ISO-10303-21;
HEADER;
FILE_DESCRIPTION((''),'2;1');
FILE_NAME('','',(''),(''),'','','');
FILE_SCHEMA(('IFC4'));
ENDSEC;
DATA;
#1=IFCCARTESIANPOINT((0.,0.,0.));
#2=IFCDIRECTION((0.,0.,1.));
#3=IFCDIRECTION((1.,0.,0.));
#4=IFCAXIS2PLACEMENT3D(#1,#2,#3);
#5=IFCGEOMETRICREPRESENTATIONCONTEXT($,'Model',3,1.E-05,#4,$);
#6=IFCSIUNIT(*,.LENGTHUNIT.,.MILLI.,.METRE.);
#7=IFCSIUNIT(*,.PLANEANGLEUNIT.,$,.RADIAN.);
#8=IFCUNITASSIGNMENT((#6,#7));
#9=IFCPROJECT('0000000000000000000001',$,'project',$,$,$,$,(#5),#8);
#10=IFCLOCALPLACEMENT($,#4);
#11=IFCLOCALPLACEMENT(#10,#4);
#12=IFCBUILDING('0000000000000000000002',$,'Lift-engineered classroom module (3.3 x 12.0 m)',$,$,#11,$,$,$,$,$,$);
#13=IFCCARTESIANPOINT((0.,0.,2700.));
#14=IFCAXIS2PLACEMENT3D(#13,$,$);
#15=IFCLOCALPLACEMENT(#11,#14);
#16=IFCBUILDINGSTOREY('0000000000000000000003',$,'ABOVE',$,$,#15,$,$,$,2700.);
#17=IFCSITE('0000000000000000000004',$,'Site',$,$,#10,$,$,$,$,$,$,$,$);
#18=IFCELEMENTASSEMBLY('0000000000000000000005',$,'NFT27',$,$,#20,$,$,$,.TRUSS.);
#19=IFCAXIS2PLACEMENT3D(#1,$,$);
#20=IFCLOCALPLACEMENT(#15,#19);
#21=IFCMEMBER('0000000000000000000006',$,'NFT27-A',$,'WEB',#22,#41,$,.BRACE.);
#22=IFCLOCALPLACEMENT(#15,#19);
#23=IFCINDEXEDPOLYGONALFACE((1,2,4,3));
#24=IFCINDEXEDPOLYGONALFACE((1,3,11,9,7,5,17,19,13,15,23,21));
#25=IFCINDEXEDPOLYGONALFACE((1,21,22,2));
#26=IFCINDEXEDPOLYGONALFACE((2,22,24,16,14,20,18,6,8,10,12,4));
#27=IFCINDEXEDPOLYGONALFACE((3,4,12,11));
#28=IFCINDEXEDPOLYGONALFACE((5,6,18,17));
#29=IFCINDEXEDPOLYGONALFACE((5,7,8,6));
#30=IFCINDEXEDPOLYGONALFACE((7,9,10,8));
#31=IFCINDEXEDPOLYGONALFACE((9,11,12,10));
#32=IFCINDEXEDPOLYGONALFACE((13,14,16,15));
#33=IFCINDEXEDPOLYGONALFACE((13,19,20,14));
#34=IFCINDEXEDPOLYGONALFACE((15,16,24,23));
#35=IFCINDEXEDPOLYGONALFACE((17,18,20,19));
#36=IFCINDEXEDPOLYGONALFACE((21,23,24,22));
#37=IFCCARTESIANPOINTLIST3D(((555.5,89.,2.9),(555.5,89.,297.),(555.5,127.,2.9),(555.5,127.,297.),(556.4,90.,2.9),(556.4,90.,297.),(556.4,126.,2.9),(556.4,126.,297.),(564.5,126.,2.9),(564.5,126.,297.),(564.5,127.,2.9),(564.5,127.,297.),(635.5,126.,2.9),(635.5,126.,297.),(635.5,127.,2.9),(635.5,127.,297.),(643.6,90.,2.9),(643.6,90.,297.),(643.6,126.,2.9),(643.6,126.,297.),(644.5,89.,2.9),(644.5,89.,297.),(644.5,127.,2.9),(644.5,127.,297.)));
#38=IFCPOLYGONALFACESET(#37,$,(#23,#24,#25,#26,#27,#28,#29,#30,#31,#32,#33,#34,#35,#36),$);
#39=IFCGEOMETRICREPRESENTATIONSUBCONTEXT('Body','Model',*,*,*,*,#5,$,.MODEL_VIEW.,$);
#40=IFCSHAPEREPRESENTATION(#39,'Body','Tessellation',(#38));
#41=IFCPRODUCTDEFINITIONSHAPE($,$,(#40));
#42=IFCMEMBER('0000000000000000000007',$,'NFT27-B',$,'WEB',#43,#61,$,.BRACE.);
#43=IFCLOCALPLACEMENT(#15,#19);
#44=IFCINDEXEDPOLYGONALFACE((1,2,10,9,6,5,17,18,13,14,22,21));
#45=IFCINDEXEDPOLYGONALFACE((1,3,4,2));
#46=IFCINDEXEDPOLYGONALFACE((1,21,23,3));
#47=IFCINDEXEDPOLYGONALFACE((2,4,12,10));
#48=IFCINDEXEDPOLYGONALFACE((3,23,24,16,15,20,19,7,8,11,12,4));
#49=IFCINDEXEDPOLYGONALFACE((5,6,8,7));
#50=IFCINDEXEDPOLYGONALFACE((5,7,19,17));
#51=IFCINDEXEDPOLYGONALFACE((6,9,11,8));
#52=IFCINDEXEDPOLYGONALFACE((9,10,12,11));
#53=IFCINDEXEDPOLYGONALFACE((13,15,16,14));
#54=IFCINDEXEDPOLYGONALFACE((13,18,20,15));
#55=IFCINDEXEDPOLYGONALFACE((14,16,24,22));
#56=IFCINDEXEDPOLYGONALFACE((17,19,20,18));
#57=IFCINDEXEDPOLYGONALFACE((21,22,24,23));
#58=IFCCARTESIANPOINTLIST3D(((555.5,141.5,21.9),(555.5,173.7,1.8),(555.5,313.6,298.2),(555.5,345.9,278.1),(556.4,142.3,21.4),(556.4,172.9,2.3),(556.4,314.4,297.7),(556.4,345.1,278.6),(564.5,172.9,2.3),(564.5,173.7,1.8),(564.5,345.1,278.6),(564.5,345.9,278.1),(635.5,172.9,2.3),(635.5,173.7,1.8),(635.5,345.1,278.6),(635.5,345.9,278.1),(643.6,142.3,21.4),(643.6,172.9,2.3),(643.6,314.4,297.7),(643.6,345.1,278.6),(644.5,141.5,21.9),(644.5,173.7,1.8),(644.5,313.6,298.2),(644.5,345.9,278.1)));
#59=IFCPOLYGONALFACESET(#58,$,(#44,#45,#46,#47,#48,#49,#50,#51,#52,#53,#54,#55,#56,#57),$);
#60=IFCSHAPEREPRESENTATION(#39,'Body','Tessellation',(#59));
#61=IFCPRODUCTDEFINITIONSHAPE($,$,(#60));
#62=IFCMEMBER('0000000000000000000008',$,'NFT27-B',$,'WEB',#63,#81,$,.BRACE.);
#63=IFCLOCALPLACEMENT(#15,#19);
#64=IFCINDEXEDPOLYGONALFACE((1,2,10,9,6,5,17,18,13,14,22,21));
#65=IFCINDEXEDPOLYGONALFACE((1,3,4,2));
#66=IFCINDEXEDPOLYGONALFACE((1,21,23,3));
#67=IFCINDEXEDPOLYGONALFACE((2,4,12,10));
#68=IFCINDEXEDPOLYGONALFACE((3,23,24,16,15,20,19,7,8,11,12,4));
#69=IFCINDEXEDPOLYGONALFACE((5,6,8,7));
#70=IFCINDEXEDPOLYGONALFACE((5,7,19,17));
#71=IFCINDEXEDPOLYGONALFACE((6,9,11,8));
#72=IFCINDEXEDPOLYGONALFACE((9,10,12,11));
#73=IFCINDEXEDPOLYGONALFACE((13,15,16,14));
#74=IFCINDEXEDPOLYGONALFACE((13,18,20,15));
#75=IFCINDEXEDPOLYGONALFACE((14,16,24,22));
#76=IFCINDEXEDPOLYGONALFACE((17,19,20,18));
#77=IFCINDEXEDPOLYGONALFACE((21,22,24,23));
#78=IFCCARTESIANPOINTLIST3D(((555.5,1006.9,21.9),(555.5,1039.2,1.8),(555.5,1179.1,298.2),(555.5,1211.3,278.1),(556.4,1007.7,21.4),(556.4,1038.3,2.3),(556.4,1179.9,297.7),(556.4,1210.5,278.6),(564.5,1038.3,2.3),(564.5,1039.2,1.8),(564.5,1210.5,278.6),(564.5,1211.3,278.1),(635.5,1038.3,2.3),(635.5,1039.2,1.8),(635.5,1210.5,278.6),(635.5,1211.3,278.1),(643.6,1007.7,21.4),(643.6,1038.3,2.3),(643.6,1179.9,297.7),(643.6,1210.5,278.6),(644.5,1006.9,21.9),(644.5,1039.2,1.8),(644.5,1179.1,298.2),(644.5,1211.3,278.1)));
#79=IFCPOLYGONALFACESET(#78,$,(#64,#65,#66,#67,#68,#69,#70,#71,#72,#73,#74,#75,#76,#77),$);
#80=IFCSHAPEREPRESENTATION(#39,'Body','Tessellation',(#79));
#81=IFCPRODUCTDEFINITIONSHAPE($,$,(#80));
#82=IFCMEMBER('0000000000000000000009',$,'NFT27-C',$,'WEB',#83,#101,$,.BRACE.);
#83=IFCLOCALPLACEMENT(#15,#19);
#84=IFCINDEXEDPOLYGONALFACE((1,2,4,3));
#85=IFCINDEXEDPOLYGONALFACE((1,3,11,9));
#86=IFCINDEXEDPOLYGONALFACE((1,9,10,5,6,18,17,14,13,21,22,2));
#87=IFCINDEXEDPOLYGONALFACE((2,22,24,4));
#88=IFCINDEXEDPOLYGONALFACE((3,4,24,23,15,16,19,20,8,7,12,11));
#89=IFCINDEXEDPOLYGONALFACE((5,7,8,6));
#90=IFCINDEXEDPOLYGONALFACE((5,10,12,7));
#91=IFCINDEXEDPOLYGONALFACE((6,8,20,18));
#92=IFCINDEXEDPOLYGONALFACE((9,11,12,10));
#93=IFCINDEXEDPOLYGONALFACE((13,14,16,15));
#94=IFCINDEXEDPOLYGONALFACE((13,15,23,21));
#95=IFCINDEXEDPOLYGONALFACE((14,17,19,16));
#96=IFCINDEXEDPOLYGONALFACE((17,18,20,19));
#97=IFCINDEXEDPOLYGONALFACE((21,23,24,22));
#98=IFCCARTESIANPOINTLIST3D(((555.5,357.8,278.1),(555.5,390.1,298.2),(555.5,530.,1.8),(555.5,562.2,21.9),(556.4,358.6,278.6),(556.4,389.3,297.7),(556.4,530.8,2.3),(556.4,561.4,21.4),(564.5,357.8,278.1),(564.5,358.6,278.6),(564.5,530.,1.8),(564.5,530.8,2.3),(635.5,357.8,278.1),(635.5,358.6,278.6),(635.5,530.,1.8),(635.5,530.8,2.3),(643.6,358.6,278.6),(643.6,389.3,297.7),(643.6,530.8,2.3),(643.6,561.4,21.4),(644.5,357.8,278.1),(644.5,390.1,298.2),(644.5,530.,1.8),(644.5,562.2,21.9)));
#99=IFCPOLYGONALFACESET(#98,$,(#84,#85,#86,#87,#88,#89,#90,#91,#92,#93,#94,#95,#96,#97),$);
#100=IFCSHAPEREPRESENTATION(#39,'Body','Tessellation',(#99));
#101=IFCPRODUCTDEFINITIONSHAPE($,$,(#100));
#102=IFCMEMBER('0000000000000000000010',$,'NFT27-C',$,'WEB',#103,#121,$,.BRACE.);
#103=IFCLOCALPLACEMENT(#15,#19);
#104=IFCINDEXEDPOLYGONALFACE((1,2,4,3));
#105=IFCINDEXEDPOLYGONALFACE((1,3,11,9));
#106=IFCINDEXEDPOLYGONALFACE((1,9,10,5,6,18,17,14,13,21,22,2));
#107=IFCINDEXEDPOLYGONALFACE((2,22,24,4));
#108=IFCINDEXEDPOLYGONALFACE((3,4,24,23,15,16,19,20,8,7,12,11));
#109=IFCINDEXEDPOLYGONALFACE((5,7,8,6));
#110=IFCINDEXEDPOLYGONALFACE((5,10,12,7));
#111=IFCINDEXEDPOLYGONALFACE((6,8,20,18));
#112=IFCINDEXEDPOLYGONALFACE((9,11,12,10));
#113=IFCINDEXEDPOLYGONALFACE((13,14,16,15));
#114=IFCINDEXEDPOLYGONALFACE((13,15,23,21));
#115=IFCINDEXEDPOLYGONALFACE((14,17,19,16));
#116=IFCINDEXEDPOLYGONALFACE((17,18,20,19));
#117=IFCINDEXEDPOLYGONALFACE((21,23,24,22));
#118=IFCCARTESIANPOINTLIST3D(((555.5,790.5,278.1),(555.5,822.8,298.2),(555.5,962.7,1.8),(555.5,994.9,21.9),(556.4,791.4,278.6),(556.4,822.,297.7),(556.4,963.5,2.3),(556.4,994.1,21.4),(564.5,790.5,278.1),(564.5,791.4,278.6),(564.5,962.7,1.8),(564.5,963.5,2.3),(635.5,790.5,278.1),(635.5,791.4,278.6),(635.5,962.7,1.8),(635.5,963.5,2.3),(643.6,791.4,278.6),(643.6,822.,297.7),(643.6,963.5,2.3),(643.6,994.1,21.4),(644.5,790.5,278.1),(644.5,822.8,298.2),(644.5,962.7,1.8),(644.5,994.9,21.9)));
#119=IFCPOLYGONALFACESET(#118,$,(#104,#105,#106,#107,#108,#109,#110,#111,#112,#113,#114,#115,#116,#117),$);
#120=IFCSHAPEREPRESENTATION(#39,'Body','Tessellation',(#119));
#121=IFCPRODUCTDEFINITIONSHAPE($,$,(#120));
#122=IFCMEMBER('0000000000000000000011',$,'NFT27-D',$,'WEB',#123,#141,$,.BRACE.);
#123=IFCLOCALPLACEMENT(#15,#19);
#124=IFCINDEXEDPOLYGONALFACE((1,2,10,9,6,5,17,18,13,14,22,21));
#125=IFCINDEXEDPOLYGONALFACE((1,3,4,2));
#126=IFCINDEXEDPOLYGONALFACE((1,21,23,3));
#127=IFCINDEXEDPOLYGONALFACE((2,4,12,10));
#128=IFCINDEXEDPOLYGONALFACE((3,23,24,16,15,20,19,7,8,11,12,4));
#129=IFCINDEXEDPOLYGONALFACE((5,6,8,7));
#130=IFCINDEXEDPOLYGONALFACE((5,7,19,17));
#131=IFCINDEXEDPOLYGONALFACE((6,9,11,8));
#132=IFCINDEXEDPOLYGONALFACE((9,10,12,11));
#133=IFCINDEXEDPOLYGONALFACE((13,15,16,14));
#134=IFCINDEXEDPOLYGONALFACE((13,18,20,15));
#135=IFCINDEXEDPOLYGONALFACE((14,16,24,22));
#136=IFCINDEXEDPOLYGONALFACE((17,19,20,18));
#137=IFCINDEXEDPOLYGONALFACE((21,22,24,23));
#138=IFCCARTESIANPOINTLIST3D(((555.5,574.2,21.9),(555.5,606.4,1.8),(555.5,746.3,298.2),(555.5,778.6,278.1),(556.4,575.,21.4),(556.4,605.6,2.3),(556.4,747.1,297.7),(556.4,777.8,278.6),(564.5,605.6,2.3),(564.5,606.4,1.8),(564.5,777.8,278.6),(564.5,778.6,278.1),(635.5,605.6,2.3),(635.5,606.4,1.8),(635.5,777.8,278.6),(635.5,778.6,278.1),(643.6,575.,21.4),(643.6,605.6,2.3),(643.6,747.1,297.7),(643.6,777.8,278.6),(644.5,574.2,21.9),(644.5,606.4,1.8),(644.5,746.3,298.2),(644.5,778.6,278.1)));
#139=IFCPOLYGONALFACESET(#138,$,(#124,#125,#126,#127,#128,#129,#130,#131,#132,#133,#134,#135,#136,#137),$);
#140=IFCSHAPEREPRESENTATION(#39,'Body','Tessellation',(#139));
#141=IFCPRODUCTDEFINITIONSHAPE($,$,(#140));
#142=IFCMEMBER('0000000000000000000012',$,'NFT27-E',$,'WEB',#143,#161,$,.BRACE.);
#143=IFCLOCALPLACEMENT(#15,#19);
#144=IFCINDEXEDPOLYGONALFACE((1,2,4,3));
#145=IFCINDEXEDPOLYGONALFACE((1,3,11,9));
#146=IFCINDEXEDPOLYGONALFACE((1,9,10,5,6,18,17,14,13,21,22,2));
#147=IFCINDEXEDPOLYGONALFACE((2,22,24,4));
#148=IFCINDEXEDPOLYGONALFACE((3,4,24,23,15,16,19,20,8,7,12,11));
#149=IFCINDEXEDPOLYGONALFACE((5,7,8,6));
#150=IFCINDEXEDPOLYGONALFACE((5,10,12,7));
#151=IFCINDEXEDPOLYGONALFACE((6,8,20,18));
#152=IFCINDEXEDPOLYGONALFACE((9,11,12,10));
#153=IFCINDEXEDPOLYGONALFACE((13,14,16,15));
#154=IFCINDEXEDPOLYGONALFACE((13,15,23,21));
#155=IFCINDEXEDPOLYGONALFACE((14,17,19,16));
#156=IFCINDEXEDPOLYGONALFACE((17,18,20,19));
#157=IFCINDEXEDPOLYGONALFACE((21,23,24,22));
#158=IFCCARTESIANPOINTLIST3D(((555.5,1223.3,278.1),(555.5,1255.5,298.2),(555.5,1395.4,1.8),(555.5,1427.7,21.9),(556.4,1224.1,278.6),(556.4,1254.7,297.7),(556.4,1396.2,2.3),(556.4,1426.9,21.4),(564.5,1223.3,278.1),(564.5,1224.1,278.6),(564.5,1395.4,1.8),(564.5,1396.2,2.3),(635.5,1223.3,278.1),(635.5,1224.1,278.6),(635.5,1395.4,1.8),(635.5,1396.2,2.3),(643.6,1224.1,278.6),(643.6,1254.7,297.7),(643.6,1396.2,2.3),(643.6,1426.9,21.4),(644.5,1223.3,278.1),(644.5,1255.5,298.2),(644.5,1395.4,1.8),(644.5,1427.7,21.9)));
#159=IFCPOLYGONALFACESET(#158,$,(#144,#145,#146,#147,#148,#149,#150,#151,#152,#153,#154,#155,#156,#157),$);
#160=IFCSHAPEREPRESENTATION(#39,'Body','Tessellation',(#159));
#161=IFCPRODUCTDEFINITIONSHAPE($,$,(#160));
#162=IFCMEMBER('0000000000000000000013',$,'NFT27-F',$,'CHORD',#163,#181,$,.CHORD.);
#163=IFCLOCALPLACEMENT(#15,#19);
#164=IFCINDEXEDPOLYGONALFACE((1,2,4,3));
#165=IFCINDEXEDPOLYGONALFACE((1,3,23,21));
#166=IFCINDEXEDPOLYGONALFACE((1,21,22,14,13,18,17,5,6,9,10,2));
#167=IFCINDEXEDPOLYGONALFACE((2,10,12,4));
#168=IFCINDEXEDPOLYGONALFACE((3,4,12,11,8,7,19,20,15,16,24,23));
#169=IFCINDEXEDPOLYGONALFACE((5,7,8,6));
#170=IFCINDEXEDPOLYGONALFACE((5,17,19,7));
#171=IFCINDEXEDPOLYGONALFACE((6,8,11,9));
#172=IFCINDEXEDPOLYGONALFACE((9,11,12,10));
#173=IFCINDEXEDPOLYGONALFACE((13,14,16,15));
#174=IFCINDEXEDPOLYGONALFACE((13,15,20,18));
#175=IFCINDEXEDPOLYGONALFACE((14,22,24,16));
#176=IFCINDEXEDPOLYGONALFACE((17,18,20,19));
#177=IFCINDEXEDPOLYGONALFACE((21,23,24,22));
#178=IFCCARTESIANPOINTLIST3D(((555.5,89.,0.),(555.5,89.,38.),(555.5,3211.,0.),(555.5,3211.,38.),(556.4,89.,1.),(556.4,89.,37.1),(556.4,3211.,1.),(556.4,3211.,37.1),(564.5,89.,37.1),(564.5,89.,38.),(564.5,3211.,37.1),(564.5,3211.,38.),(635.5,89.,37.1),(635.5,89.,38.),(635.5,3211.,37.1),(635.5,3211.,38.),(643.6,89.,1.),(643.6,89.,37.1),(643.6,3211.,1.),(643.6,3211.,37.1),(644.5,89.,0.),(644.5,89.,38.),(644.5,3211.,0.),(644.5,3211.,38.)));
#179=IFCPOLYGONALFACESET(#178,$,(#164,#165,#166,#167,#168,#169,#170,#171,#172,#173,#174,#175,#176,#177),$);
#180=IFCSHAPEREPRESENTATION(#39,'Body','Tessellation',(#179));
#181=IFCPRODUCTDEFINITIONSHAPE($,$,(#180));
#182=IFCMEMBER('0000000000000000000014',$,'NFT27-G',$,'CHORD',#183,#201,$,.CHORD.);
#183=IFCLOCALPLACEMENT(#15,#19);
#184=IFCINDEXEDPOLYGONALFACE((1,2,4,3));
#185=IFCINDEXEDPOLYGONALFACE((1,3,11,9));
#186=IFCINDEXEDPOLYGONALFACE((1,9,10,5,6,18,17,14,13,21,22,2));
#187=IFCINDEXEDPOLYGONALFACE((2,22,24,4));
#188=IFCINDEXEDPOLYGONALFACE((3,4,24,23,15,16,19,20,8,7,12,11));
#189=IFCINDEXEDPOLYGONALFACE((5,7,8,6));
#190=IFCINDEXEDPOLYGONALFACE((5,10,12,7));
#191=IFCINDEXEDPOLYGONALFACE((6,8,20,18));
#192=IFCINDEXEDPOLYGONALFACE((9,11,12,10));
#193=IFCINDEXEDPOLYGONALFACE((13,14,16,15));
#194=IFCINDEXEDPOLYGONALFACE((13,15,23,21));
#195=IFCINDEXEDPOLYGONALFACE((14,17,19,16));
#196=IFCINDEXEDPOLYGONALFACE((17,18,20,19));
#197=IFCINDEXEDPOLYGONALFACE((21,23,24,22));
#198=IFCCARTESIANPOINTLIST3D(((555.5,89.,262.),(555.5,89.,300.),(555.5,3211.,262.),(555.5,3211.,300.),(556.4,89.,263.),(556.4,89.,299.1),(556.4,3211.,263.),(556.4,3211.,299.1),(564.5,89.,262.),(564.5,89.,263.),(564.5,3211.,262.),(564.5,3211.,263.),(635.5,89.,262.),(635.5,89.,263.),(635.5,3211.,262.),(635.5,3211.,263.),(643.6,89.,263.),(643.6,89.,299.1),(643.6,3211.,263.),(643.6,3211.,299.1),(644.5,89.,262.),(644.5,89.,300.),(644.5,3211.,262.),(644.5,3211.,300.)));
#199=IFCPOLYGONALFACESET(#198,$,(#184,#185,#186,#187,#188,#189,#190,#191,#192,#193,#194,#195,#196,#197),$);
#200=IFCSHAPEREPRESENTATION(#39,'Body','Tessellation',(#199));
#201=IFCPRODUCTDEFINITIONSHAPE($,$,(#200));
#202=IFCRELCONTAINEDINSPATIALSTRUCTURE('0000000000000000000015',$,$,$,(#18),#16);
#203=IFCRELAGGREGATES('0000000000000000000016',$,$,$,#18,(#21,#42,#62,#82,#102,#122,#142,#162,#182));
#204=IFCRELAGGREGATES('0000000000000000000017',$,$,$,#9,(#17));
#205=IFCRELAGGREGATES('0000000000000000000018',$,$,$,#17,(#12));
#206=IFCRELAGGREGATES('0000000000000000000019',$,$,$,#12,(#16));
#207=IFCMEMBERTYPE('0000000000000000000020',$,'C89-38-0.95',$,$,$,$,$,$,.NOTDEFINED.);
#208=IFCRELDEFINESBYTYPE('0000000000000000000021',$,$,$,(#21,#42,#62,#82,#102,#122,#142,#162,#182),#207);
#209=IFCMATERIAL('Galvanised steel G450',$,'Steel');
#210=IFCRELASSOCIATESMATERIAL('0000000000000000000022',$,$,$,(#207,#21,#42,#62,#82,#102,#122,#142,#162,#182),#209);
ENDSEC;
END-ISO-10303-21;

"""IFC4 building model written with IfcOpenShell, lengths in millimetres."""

from ifc_helpers import new_model, si_unit, frame, origin, origin_with_axes, origin_2d, place, context, subcontext, project, spatial, c_section, extrude, material, material_profile, profile_set, profile_usage, type_object, element, aggregate, save


model = new_model("IFC4")

# Units and contexts
model_context = context("Model", 3, precision=1e-05, world=origin_with_axes())
body_context = subcontext(model_context, "Body", "Model", "MODEL_VIEW")
ifc_project = project(units=[si_unit("LENGTHUNIT", "METRE", prefix="MILLI"), si_unit("PLANEANGLEUNIT", "RADIAN")], contexts=[model_context])

# Site, building, storey
site_placement = place(None, origin_with_axes())
site = spatial("IfcSite", under=ifc_project, at=site_placement, Name="Site")
building_placement = place(site_placement, origin_with_axes())
building = spatial("IfcBuilding", under=site, at=building_placement, Name="Lift-engineered classroom module (3.3 x 12.0 m)")
storey_placement = place(building_placement, frame((0.0, 0.0, 2700.0)))
storey = spatial("IfcBuildingStorey", under=building, at=storey_placement, Name="ABOVE", Elevation=2700.0)

# Element assembly, members
ifc_material = material(Name="Galvanised steel G450", Category="Steel")
ifc_material_profile = material_profile(ifc_material, c_section(Depth=89.0, Width=38.0, WallThickness=0.9, Girth=9.0, at=origin_2d()), Name="C89-38-0.95")
ifc_profile_set = profile_set([ifc_material_profile], Name="C89-38-0.95")
ifc_profile_usage = profile_usage(ifc_profile_set)
member_type = type_object("IfcMemberType", Name="C89-38-0.95", PredefinedType="NOTDEFINED", material=ifc_profile_set)
assembly_1_placement = place(storey_placement, frame((600.0, 89.0, 0.0)))
assembly_1 = element("IfcElementAssembly", 1, at=assembly_1_placement, inside=storey, Name="NFT27", PredefinedType="TRUSS")
member_1_placement = place(assembly_1_placement, frame((0.0, 19.0, 2.9), z_axis=(0.0, 0.0, 1.0), x_axis=(0.0, 1.0, 0.0)))
member_1 = element("IfcMember", 2, at=member_1_placement, type_object=member_type, material=ifc_profile_usage, Name="NFT27-A", ObjectType="WEB", PredefinedType="BRACE", context=body_context, shape_type="SweptSolid", body=[
    extrude(c_section(Depth=89.0, Width=38.0, WallThickness=0.9, Girth=9.0, at=origin_2d()), origin(), (0.0, 0.0, 1.0), 294.1),
])
member_2_placement = place(assembly_1_placement, frame((0.0, 68.6, 11.8), z_axis=(0.0, 0.528797, 0.848748), x_axis=(0.0, 0.848748, -0.528797)))
member_2 = element("IfcMember", 3, at=member_2_placement, type_object=member_type, material=ifc_profile_usage, Name="NFT27-B", ObjectType="WEB", PredefinedType="BRACE", context=body_context, shape_type="SweptSolid", body=[
    extrude(c_section(Depth=89.0, Width=38.0, WallThickness=0.9, Girth=9.0, at=origin_2d()), origin(), (0.0, 0.0, 1.0), 325.6),
])
member_3_placement = place(assembly_1_placement, frame((0.0, 934.0, 11.8), z_axis=(0.0, 0.528797, 0.848748), x_axis=(0.0, 0.848748, -0.528797)))
member_3 = element("IfcMember", 4, at=member_3_placement, type_object=member_type, material=ifc_profile_usage, Name="NFT27-B", ObjectType="WEB", PredefinedType="BRACE", context=body_context, shape_type="SweptSolid", body=[
    extrude(c_section(Depth=89.0, Width=38.0, WallThickness=0.9, Girth=9.0, at=origin_2d()), origin(), (0.0, 0.0, 1.0), 325.6),
])
member_4_placement = place(assembly_1_placement, frame((0.0, 457.1, 11.8), z_axis=(0.0, -0.528797, 0.848748), x_axis=(0.0, -0.848748, -0.528797)))
member_4 = element("IfcMember", 5, at=member_4_placement, type_object=member_type, material=ifc_profile_usage, Name="NFT27-C", ObjectType="WEB", PredefinedType="BRACE", context=body_context, shape_type="SweptSolid", body=[
    extrude(c_section(Depth=89.0, Width=38.0, WallThickness=0.9, Girth=9.0, at=origin_2d()), origin(), (0.0, 0.0, 1.0), 325.6),
])
member_5_placement = place(assembly_1_placement, frame((0.0, 889.8, 11.8), z_axis=(0.0, -0.528797, 0.848748), x_axis=(0.0, -0.848748, -0.528797)))
member_5 = element("IfcMember", 6, at=member_5_placement, type_object=member_type, material=ifc_profile_usage, Name="NFT27-C", ObjectType="WEB", PredefinedType="BRACE", context=body_context, shape_type="SweptSolid", body=[
    extrude(c_section(Depth=89.0, Width=38.0, WallThickness=0.9, Girth=9.0, at=origin_2d()), origin(), (0.0, 0.0, 1.0), 325.6),
])
member_6_placement = place(assembly_1_placement, frame((0.0, 501.3, 11.8), z_axis=(0.0, 0.528775, 0.848762), x_axis=(0.0, 0.848762, -0.528775)))
member_6 = element("IfcMember", 7, at=member_6_placement, type_object=member_type, material=ifc_profile_usage, Name="NFT27-D", ObjectType="WEB", PredefinedType="BRACE", context=body_context, shape_type="SweptSolid", body=[
    extrude(c_section(Depth=89.0, Width=38.0, WallThickness=0.9, Girth=9.0, at=origin_2d()), origin(), (0.0, 0.0, 1.0), 325.6),
])
member_7_placement = place(assembly_1_placement, frame((0.0, 1322.5, 11.8), z_axis=(0.0, -0.528775, 0.848762), x_axis=(0.0, -0.848762, -0.528775)))
member_7 = element("IfcMember", 8, at=member_7_placement, type_object=member_type, material=ifc_profile_usage, Name="NFT27-E", ObjectType="WEB", PredefinedType="BRACE", context=body_context, shape_type="SweptSolid", body=[
    extrude(c_section(Depth=89.0, Width=38.0, WallThickness=0.9, Girth=9.0, at=origin_2d()), origin(), (0.0, 0.0, 1.0), 325.6),
])
member_8_placement = place(assembly_1_placement, frame((0.0, 0.0, 19.0), z_axis=(0.0, 1.0, 0.0), x_axis=(0.0, 0.0, 1.0)))
member_8 = element("IfcMember", 9, at=member_8_placement, type_object=member_type, material=ifc_profile_usage, Name="NFT27-F", ObjectType="CHORD", PredefinedType="CHORD", context=body_context, shape_type="SweptSolid", body=[
    extrude(c_section(Depth=89.0, Width=38.0, WallThickness=0.9, Girth=9.0, at=origin_2d()), origin(), (0.0, 0.0, 1.0), 3122.0),
])
member_9_placement = place(assembly_1_placement, frame((0.0, 0.0, 281.0), z_axis=(0.0, 1.0, 0.0), x_axis=(0.0, 0.0, -1.0)))
member_9 = element("IfcMember", 10, at=member_9_placement, type_object=member_type, material=ifc_profile_usage, Name="NFT27-G", ObjectType="CHORD", PredefinedType="CHORD", context=body_context, shape_type="SweptSolid", body=[
    extrude(c_section(Depth=89.0, Width=38.0, WallThickness=0.9, Girth=9.0, at=origin_2d()), origin(), (0.0, 0.0, 1.0), 3122.0),
])
aggregate(assembly_1, [member_1, member_2, member_3, member_4, member_5, member_6, member_7, member_8, member_9])

save(model, "model.ifc")
